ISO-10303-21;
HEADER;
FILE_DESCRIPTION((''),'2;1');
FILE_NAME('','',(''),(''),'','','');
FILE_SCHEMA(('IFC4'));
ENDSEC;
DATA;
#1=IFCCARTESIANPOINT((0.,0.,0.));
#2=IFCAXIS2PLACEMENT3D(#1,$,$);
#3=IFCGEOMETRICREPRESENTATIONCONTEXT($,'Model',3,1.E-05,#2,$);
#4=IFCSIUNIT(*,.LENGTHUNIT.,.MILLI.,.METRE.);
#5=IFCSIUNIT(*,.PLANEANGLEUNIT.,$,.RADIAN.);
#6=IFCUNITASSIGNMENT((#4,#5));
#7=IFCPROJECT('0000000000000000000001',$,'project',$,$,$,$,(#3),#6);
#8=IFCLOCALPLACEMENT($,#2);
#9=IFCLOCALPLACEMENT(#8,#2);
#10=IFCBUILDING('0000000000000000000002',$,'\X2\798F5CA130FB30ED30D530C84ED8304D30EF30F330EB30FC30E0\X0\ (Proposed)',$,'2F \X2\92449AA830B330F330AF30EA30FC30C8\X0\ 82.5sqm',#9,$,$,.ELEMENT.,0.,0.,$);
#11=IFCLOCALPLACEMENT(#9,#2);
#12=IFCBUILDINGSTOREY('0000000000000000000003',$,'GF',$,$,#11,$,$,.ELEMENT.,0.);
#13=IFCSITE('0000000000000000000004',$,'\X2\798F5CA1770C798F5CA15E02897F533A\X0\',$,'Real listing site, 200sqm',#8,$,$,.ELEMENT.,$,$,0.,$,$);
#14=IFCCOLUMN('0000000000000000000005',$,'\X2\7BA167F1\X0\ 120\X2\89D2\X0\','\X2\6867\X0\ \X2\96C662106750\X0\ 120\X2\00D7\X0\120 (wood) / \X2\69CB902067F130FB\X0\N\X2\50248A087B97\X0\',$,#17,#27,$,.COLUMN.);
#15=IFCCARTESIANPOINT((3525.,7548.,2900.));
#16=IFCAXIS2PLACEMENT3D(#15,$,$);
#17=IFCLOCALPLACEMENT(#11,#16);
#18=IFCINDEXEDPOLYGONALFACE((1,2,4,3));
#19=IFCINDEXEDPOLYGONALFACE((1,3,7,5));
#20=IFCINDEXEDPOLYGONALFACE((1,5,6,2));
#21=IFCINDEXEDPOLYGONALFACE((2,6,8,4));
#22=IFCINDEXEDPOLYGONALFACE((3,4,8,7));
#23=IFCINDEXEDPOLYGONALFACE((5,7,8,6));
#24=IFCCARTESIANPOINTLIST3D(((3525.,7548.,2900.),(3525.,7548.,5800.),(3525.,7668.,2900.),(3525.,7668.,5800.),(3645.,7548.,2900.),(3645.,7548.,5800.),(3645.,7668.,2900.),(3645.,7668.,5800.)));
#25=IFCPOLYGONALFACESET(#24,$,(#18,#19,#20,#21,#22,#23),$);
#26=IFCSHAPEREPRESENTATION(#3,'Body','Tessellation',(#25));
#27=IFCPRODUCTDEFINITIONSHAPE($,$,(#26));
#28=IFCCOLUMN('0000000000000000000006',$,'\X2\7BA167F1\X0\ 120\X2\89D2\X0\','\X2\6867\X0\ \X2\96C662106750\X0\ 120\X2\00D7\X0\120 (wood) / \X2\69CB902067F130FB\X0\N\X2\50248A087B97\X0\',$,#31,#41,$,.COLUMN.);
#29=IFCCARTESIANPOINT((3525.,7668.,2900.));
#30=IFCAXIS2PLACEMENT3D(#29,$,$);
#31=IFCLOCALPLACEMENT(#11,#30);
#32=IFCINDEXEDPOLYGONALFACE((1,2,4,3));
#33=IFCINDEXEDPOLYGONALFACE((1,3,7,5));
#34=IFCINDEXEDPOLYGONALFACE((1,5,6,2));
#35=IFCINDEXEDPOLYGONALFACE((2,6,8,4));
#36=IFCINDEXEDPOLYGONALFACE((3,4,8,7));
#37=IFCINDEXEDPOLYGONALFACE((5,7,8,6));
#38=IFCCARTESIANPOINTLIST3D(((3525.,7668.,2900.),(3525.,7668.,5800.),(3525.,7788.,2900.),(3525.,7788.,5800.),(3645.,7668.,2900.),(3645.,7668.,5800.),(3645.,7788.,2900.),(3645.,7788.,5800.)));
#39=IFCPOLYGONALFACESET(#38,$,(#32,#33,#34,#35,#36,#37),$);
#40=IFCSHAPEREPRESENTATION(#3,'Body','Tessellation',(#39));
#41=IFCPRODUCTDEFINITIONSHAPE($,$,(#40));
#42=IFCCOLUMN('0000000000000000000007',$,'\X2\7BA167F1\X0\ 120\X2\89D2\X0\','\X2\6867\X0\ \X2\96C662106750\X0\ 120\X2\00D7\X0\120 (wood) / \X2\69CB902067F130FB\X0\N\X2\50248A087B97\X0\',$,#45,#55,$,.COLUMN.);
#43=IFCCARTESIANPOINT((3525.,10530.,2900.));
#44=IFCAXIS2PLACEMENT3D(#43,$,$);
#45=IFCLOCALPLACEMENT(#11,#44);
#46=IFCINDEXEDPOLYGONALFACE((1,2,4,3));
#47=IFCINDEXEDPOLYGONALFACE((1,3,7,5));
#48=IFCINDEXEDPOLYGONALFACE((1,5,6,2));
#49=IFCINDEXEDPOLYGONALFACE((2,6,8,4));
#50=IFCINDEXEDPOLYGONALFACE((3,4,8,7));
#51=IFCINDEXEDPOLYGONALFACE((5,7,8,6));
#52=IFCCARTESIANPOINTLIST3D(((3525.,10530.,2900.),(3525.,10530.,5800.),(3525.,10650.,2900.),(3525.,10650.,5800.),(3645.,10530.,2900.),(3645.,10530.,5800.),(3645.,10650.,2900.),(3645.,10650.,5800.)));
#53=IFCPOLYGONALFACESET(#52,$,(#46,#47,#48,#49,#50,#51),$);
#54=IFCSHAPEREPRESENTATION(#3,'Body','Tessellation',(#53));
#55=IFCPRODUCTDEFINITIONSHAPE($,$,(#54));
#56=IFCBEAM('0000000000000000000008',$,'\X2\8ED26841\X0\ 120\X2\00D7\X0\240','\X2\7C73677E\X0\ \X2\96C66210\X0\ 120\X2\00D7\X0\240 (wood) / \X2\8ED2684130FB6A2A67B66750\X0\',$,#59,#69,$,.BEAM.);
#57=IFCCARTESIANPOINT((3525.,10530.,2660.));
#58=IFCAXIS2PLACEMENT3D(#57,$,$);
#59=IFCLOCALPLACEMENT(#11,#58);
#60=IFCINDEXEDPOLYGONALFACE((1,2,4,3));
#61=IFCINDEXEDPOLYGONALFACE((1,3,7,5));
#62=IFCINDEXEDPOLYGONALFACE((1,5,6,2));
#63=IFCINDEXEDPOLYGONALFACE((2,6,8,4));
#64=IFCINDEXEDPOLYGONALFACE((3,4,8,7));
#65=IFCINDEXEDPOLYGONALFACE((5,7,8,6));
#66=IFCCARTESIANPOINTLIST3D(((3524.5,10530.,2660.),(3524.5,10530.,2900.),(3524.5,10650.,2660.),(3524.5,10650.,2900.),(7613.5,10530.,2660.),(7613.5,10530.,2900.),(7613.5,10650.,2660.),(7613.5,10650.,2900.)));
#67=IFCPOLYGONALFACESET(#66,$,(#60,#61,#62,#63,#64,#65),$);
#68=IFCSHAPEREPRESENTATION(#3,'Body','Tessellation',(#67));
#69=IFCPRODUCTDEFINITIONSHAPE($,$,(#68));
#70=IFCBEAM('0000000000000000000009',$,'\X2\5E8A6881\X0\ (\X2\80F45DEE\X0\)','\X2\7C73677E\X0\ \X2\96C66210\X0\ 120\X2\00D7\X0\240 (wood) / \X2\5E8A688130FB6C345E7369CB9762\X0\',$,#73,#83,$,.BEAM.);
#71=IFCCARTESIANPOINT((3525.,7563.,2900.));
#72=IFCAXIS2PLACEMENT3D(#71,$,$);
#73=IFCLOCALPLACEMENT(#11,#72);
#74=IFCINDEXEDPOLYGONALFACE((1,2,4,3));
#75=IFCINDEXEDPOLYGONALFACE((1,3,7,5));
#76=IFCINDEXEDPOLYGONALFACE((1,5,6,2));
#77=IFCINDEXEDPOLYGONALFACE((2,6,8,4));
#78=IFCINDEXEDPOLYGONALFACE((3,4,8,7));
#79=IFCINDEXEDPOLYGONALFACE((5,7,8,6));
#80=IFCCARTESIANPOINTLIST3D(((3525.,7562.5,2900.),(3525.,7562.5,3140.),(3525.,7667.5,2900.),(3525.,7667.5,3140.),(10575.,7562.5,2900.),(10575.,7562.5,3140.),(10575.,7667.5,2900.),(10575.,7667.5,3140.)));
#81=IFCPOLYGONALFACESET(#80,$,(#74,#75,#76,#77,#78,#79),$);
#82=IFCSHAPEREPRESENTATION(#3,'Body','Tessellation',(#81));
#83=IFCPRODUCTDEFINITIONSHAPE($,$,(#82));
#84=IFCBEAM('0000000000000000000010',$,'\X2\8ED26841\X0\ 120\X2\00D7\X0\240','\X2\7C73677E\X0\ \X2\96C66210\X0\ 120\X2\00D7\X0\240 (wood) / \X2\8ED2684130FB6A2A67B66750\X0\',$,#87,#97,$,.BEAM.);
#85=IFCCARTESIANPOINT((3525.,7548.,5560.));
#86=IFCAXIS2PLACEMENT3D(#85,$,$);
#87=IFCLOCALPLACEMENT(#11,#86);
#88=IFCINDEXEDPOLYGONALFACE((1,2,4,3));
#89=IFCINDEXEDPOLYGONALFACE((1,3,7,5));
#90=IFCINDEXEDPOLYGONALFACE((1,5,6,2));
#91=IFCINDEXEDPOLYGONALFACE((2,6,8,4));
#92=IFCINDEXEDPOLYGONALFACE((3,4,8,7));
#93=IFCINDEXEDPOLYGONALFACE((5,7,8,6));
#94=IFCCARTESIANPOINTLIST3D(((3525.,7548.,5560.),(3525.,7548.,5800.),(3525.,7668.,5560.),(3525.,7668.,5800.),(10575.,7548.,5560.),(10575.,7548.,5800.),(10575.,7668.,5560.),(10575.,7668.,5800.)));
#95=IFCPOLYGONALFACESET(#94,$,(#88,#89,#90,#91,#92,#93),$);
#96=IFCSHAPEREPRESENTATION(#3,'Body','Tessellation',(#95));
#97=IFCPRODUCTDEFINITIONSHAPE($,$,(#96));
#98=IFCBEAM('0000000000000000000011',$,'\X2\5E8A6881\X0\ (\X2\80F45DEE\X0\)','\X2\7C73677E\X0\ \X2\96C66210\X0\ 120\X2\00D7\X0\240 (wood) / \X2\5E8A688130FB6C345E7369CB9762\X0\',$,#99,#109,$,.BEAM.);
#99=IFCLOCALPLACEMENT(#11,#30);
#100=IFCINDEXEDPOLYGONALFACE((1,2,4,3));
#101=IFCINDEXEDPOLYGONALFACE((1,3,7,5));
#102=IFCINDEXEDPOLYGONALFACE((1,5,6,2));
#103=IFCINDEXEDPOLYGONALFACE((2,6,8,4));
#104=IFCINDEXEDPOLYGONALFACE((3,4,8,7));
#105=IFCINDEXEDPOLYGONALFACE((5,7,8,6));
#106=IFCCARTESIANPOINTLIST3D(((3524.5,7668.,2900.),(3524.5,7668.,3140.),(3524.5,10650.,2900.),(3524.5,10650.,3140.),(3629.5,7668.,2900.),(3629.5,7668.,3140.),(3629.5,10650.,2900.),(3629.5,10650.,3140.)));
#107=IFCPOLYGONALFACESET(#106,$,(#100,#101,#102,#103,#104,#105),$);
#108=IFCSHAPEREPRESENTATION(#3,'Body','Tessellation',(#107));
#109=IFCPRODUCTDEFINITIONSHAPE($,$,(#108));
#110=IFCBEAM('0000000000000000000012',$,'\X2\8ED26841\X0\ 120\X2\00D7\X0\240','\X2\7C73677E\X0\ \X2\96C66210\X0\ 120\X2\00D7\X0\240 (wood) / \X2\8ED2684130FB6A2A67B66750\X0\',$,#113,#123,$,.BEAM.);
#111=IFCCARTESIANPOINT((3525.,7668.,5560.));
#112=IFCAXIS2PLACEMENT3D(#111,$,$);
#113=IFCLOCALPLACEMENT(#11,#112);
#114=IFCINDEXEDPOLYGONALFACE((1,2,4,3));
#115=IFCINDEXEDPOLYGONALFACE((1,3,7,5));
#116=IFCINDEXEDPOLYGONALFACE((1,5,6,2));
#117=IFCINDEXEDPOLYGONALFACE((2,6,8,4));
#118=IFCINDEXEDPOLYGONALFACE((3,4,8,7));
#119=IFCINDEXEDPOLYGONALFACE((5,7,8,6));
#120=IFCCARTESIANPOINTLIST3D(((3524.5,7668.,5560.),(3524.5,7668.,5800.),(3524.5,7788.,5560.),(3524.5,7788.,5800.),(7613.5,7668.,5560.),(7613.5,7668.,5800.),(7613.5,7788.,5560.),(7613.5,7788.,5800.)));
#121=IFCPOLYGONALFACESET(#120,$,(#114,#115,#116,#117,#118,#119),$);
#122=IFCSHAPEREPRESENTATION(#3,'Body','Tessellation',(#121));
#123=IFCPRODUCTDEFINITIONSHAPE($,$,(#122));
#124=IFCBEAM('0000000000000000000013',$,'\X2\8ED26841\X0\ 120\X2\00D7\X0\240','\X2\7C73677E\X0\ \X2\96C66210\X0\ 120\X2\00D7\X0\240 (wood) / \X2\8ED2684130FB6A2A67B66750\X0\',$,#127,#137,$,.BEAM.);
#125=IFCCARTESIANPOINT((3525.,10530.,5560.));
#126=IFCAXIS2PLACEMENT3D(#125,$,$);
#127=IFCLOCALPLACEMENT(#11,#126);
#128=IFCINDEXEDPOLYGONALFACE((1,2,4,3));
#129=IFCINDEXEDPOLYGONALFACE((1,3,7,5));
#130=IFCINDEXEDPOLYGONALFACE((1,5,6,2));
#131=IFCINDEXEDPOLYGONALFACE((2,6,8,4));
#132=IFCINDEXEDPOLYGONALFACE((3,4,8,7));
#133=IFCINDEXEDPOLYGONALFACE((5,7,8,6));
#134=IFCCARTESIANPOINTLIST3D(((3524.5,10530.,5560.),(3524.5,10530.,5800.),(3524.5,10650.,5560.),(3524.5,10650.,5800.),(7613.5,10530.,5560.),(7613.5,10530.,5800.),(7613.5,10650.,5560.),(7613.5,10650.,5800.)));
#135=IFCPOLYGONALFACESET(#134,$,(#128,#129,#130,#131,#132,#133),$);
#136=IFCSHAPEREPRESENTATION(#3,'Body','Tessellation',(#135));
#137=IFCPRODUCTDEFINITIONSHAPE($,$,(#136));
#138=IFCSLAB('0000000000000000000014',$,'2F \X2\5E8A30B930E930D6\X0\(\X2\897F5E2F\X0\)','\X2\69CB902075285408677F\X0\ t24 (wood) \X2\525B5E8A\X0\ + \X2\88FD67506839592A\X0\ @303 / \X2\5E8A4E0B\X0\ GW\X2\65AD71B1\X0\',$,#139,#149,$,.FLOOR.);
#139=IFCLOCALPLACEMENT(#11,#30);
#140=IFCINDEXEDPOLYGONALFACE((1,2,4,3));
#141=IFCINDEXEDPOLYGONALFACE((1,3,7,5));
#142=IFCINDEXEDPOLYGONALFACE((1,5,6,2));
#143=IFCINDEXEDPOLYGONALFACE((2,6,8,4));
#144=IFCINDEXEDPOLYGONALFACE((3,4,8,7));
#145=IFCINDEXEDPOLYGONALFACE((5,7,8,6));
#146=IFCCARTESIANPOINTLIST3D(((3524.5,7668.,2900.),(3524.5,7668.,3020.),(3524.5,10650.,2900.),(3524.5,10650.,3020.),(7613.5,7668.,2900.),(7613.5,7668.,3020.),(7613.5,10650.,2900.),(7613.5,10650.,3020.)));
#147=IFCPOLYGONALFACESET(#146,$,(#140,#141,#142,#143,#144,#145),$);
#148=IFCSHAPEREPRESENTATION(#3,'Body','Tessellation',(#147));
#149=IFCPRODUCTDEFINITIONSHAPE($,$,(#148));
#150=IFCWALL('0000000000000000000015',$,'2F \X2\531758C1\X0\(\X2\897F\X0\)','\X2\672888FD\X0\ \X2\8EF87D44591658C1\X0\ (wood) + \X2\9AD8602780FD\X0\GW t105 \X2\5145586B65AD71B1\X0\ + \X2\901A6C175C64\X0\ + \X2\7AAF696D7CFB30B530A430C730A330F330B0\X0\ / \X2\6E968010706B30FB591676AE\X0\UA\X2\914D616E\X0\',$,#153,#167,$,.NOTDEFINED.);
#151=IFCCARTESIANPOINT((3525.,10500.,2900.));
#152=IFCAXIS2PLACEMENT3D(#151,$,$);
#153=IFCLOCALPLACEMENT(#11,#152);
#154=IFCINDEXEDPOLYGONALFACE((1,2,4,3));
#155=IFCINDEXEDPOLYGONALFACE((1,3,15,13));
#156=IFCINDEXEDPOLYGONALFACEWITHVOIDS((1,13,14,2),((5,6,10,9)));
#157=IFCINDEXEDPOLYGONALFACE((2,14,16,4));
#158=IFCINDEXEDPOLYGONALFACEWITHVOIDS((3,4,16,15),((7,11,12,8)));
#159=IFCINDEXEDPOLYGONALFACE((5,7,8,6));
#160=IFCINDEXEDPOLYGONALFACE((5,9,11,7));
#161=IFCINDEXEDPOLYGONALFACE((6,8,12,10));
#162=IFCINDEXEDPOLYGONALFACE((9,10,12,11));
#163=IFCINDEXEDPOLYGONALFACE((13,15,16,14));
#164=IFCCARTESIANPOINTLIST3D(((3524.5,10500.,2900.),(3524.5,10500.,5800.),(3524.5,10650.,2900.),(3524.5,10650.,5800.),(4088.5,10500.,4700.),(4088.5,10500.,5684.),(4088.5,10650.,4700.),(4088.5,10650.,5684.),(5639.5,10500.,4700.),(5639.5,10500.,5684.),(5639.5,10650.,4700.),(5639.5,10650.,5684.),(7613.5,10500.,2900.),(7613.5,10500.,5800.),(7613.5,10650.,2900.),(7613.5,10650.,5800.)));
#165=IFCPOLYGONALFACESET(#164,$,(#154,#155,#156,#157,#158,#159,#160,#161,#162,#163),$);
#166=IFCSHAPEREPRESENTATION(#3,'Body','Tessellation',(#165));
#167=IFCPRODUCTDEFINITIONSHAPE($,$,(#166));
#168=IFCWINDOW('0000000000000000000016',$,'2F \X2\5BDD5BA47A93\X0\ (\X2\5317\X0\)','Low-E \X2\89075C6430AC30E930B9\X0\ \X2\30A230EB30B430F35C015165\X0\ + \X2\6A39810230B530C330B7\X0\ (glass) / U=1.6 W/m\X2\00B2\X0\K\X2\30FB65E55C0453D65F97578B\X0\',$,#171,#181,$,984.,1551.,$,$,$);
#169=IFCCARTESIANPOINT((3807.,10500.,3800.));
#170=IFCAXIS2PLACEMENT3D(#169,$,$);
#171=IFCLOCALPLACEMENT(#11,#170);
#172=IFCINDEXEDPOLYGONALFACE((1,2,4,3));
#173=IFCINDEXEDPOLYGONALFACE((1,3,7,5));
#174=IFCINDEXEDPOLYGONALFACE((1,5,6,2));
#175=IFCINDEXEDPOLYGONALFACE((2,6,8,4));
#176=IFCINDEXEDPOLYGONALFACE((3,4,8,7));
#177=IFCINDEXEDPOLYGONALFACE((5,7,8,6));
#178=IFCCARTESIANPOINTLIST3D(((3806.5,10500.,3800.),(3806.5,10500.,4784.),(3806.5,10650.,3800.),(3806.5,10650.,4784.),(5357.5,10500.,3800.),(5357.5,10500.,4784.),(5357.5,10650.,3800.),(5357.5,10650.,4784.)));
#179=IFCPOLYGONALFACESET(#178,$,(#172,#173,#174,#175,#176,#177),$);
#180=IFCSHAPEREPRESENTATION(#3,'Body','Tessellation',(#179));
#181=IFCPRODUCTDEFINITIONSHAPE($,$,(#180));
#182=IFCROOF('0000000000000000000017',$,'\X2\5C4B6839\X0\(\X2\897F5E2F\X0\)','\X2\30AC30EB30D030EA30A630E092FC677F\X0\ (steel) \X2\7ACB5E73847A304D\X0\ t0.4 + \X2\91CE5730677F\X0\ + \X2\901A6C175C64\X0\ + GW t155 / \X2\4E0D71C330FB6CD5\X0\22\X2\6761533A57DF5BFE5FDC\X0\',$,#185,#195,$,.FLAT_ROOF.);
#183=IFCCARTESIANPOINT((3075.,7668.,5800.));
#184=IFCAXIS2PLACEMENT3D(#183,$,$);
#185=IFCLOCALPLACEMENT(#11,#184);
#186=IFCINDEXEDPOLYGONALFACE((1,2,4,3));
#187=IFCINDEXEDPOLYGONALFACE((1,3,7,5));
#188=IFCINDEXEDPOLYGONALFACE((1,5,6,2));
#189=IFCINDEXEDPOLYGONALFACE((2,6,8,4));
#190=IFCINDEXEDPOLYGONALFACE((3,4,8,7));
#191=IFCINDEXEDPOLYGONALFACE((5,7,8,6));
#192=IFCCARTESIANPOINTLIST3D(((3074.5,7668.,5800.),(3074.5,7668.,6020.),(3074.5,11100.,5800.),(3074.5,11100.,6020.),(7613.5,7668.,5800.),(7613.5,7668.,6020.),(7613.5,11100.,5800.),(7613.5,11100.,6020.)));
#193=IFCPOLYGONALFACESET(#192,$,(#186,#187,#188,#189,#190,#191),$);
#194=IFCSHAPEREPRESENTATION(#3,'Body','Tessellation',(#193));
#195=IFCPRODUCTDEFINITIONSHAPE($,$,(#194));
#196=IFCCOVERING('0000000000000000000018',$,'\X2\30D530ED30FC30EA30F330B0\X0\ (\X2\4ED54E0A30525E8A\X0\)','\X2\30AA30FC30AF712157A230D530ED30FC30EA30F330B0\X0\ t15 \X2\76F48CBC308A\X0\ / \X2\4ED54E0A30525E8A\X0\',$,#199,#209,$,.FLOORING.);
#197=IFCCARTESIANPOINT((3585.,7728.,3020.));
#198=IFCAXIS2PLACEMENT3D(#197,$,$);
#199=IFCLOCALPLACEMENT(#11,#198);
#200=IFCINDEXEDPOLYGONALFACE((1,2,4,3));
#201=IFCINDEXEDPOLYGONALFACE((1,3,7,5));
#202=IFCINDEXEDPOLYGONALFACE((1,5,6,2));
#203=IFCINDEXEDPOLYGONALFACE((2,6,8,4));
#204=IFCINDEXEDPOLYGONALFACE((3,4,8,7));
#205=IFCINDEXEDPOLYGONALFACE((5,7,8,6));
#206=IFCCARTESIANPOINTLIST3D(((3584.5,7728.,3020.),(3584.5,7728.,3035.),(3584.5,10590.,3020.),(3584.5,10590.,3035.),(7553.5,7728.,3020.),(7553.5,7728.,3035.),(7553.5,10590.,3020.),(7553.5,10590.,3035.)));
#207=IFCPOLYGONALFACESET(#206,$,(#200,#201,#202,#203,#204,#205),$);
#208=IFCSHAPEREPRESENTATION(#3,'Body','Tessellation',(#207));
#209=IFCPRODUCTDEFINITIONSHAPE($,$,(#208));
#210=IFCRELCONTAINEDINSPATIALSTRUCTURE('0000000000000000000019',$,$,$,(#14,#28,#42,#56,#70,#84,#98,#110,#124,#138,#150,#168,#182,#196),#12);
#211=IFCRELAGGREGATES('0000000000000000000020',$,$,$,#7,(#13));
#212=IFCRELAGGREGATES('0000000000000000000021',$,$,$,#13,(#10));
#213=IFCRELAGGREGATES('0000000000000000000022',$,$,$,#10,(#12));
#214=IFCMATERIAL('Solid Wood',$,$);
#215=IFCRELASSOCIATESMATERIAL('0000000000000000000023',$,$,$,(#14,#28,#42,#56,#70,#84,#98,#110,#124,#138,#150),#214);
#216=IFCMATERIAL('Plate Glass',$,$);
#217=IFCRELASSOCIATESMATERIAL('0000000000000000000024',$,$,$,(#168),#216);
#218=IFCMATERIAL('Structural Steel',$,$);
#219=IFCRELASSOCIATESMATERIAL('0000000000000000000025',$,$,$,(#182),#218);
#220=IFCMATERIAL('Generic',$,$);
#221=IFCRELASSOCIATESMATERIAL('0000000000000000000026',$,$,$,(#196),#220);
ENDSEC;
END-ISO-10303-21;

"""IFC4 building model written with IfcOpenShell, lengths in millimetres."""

from ifc_helpers import new_model, si_unit, frame, frame_2d, origin, place, context, project, spatial, rectangle, extrude, material, element, fill, save


model = new_model("IFC4")

# Units and contexts
model_context = context("Model", 3, precision=1e-05, world=origin())
ifc_project = project(units=[si_unit("LENGTHUNIT", "METRE", prefix="MILLI"), si_unit("PLANEANGLEUNIT", "RADIAN")], contexts=[model_context])

# Site, building, storey
site_placement = place(None, origin())
site = spatial("IfcSite", under=ifc_project, at=site_placement, Name="福岡県福岡市西区", ObjectType="Real listing site, 200sqm", CompositionType="ELEMENT", RefElevation=0.0)
building_placement = place(site_placement, origin())
building = spatial("IfcBuilding", under=site, at=building_placement, Name="福岡・ロフト付きワンルーム (Proposed)", ObjectType="2F 鉄骨コンクリート 82.5sqm", CompositionType="ELEMENT", ElevationOfRefHeight=0.0, ElevationOfTerrain=0.0)
storey_placement = place(building_placement, origin())
storey = spatial("IfcBuildingStorey", under=building, at=storey_placement, Name="GF", CompositionType="ELEMENT", Elevation=0.0)

# Columns
ifc_material_1 = material(Name="Solid Wood")
column_1_placement = place(storey_placement, frame((3525.0, 7548.0, 2900.0)))
element("IfcColumn", 1, at=column_1_placement, inside=storey, material=ifc_material_1, Name="管柱 120角", Description="桧 集成材 120×120 (wood) / 構造柱・N値計算", PredefinedType="COLUMN", context=model_context, shape_type="SweptSolid", body=[
    extrude(rectangle(XDim=120.0, YDim=120.0, at=frame_2d((60.0, 60.0))), frame((3525.0, 7548.0, 2900.0)), (0.0, 0.0, 1.0), 2900.0),
])
column_2_placement = place(storey_placement, frame((3525.0, 7668.0, 2900.0)))
element("IfcColumn", 2, at=column_2_placement, inside=storey, material=ifc_material_1, Name="管柱 120角", Description="桧 集成材 120×120 (wood) / 構造柱・N値計算", PredefinedType="COLUMN", context=model_context, shape_type="SweptSolid", body=[
    extrude(rectangle(XDim=120.0, YDim=120.0, at=frame_2d((60.0, 60.0))), frame((3525.0, 7668.0, 2900.0)), (0.0, 0.0, 1.0), 2900.0),
])
column_3_placement = place(storey_placement, frame((3525.0, 10530.0, 2900.0)))
element("IfcColumn", 3, at=column_3_placement, inside=storey, material=ifc_material_1, Name="管柱 120角", Description="桧 集成材 120×120 (wood) / 構造柱・N値計算", PredefinedType="COLUMN", context=model_context, shape_type="SweptSolid", body=[
    extrude(rectangle(XDim=120.0, YDim=120.0, at=frame_2d((60.0, 60.0))), frame((3525.0, 10530.0, 2900.0)), (0.0, 0.0, 1.0), 2900.0),
])

# Beams
beam_1_placement = place(storey_placement, frame((3525.0, 10530.0, 2660.0)))
element("IfcBeam", 4, at=beam_1_placement, inside=storey, material=ifc_material_1, Name="軒桁 120×240", Description="米松 集成 120×240 (wood) / 軒桁・横架材", PredefinedType="BEAM", context=model_context, shape_type="SweptSolid", body=[
    extrude(rectangle(XDim=4089.0, YDim=120.0, at=frame_2d((2044.0, 60.0))), frame((3525.0, 10530.0, 2660.0)), (0.0, 0.0, 1.0), 240.0),
])
beam_2_placement = place(storey_placement, frame((3525.0, 7563.0, 2900.0)))
element("IfcBeam", 5, at=beam_2_placement, inside=storey, material=ifc_material_1, Name="床梁 (胴差)", Description="米松 集成 120×240 (wood) / 床梁・水平構面", PredefinedType="BEAM", context=model_context, shape_type="SweptSolid", body=[
    extrude(rectangle(XDim=7050.0, YDim=105.0, at=frame_2d((3525.0, 52.0))), frame((3525.0, 7563.0, 2900.0)), (0.0, 0.0, 1.0), 240.0),
])
beam_3_placement = place(storey_placement, frame((3525.0, 7548.0, 5560.0)))
element("IfcBeam", 6, at=beam_3_placement, inside=storey, material=ifc_material_1, Name="軒桁 120×240", Description="米松 集成 120×240 (wood) / 軒桁・横架材", PredefinedType="BEAM", context=model_context, shape_type="SweptSolid", body=[
    extrude(rectangle(XDim=7050.0, YDim=120.0, at=frame_2d((3525.0, 60.0))), frame((3525.0, 7548.0, 5560.0)), (0.0, 0.0, 1.0), 240.0),
])
beam_4_placement = place(storey_placement, frame((3525.0, 7668.0, 2900.0)))
element("IfcBeam", 7, at=beam_4_placement, inside=storey, material=ifc_material_1, Name="床梁 (胴差)", Description="米松 集成 120×240 (wood) / 床梁・水平構面", PredefinedType="BEAM", context=model_context, shape_type="SweptSolid", body=[
    extrude(rectangle(XDim=105.0, YDim=2982.0, at=frame_2d((52.0, 1491.0))), frame((3525.0, 7668.0, 2900.0)), (0.0, 0.0, 1.0), 240.0),
])
beam_5_placement = place(storey_placement, frame((3525.0, 7668.0, 5560.0)))
element("IfcBeam", 8, at=beam_5_placement, inside=storey, material=ifc_material_1, Name="軒桁 120×240", Description="米松 集成 120×240 (wood) / 軒桁・横架材", PredefinedType="BEAM", context=model_context, shape_type="SweptSolid", body=[
    extrude(rectangle(XDim=4089.0, YDim=120.0, at=frame_2d((2044.0, 60.0))), frame((3525.0, 7668.0, 5560.0)), (0.0, 0.0, 1.0), 240.0),
])
beam_6_placement = place(storey_placement, frame((3525.0, 10530.0, 5560.0)))
element("IfcBeam", 9, at=beam_6_placement, inside=storey, material=ifc_material_1, Name="軒桁 120×240", Description="米松 集成 120×240 (wood) / 軒桁・横架材", PredefinedType="BEAM", context=model_context, shape_type="SweptSolid", body=[
    extrude(rectangle(XDim=4089.0, YDim=120.0, at=frame_2d((2044.0, 60.0))), frame((3525.0, 10530.0, 5560.0)), (0.0, 0.0, 1.0), 240.0),
])

# Slab
slab_placement = place(storey_placement, frame((3525.0, 7668.0, 2900.0)))
element("IfcSlab", 10, at=slab_placement, inside=storey, material=ifc_material_1, Name="2F 床スラブ(西帯)", Description="構造用合板 t24 (wood) 剛床 + 製材根太 @303 / 床下 GW断熱", PredefinedType="FLOOR", context=model_context, shape_type="SweptSolid", body=[
    extrude(rectangle(XDim=4089.0, YDim=2982.0, at=frame_2d((2044.0, 1491.0))), frame((3525.0, 7668.0, 2900.0)), (0.0, 0.0, 1.0), 120.0),
])

# Wall, opening, window
wall_1_placement = place(storey_placement, frame((3525.0, 10500.0, 2900.0)))
wall_1 = element("IfcWall", 11, at=wall_1_placement, inside=storey, material=ifc_material_1, Name="2F 北壁(西)", Description="木製 軸組外壁 (wood) + 高性能GW t105 充填断熱 + 通気層 + 窯業系サイディング / 準耐火・外皮UA配慮", PredefinedType="NOTDEFINED", context=model_context, shape_type="SweptSolid", body=[
    extrude(rectangle(XDim=4089.0, YDim=150.0, at=frame_2d((2044.0, 75.0))), frame((3525.0, 10500.0, 2900.0)), (0.0, 0.0, 1.0), 2900.0),
])
opening_placement = place(storey_placement, frame((3807.0, 10500.0, 3800.0)))
opening = element("IfcOpeningElement", 12, at=opening_placement, cuts=wall_1, PredefinedType="NOTDEFINED", context=model_context, shape_type="SweptSolid", body=[
    extrude(rectangle(XDim=1551.0, YDim=150.0, at=frame_2d((775.0, 75.0))), frame((3807.0, 10500.0, 3800.0)), (0.0, 0.0, 1.0), 984.0),
])
ifc_material_2 = material(Name="Plate Glass")
window_placement = place(storey_placement, frame((3807.0, 10500.0, 3800.0)))
window = element("IfcWindow", 13, at=window_placement, inside=storey, material=ifc_material_2, Name="2F 寝室窓 (北)", Description="Low-E 複層ガラス アルゴン封入 + 樹脂サッシ (glass) / U=1.6 W/m²K・日射取得型", OverallHeight=984.0, OverallWidth=1551.0, context=model_context, shape_type="SweptSolid", body=[
    extrude(rectangle(XDim=1551.0, YDim=150.0, at=frame_2d((775.0, 75.0))), frame((3807.0, 10500.0, 3800.0)), (0.0, 0.0, 1.0), 984.0),
])
fill(opening, window)

# Roof
ifc_material_3 = material(Name="Structural Steel")
for number, where, name in (
    (14, (3075.0, 7668.0, 5800.0), "屋根(西帯)"),
):
    element("IfcRoof", number, at=place(storey_placement, frame(where)), inside=storey, material=ifc_material_3, Name=name, Description="ガルバリウム鋼板 (steel) 立平葺き t0.4 + 野地板 + 通気層 + GW t155 / 不燃・法22条区域対応", PredefinedType="FLAT_ROOF", context=model_context, shape_type="SweptSolid", body=[
        extrude(rectangle(XDim=4539.0, YDim=3432.0, at=frame_2d((2269.0, 1716.0))), frame((3075.0, 7668.0, 5800.0)), (0.0, 0.0, 1.0), 220.0),
    ])

# Covering
ifc_material_4 = material(Name="Generic")
covering_placement = place(storey_placement, frame((3585.0, 7728.0, 3020.0)))
element("IfcCovering", 15, at=covering_placement, inside=storey, material=ifc_material_4, Name="フローリング (仕上げ床)", Description="オーク無垢フローリング t15 直貼り / 仕上げ床", PredefinedType="FLOORING", context=model_context, shape_type="SweptSolid", body=[
    extrude(rectangle(XDim=3969.0, YDim=2862.0, at=frame_2d((1984.0, 1431.0))), frame((3585.0, 7728.0, 3020.0)), (0.0, 0.0, 1.0), 15.0),
])

save(model, "model.ifc")
